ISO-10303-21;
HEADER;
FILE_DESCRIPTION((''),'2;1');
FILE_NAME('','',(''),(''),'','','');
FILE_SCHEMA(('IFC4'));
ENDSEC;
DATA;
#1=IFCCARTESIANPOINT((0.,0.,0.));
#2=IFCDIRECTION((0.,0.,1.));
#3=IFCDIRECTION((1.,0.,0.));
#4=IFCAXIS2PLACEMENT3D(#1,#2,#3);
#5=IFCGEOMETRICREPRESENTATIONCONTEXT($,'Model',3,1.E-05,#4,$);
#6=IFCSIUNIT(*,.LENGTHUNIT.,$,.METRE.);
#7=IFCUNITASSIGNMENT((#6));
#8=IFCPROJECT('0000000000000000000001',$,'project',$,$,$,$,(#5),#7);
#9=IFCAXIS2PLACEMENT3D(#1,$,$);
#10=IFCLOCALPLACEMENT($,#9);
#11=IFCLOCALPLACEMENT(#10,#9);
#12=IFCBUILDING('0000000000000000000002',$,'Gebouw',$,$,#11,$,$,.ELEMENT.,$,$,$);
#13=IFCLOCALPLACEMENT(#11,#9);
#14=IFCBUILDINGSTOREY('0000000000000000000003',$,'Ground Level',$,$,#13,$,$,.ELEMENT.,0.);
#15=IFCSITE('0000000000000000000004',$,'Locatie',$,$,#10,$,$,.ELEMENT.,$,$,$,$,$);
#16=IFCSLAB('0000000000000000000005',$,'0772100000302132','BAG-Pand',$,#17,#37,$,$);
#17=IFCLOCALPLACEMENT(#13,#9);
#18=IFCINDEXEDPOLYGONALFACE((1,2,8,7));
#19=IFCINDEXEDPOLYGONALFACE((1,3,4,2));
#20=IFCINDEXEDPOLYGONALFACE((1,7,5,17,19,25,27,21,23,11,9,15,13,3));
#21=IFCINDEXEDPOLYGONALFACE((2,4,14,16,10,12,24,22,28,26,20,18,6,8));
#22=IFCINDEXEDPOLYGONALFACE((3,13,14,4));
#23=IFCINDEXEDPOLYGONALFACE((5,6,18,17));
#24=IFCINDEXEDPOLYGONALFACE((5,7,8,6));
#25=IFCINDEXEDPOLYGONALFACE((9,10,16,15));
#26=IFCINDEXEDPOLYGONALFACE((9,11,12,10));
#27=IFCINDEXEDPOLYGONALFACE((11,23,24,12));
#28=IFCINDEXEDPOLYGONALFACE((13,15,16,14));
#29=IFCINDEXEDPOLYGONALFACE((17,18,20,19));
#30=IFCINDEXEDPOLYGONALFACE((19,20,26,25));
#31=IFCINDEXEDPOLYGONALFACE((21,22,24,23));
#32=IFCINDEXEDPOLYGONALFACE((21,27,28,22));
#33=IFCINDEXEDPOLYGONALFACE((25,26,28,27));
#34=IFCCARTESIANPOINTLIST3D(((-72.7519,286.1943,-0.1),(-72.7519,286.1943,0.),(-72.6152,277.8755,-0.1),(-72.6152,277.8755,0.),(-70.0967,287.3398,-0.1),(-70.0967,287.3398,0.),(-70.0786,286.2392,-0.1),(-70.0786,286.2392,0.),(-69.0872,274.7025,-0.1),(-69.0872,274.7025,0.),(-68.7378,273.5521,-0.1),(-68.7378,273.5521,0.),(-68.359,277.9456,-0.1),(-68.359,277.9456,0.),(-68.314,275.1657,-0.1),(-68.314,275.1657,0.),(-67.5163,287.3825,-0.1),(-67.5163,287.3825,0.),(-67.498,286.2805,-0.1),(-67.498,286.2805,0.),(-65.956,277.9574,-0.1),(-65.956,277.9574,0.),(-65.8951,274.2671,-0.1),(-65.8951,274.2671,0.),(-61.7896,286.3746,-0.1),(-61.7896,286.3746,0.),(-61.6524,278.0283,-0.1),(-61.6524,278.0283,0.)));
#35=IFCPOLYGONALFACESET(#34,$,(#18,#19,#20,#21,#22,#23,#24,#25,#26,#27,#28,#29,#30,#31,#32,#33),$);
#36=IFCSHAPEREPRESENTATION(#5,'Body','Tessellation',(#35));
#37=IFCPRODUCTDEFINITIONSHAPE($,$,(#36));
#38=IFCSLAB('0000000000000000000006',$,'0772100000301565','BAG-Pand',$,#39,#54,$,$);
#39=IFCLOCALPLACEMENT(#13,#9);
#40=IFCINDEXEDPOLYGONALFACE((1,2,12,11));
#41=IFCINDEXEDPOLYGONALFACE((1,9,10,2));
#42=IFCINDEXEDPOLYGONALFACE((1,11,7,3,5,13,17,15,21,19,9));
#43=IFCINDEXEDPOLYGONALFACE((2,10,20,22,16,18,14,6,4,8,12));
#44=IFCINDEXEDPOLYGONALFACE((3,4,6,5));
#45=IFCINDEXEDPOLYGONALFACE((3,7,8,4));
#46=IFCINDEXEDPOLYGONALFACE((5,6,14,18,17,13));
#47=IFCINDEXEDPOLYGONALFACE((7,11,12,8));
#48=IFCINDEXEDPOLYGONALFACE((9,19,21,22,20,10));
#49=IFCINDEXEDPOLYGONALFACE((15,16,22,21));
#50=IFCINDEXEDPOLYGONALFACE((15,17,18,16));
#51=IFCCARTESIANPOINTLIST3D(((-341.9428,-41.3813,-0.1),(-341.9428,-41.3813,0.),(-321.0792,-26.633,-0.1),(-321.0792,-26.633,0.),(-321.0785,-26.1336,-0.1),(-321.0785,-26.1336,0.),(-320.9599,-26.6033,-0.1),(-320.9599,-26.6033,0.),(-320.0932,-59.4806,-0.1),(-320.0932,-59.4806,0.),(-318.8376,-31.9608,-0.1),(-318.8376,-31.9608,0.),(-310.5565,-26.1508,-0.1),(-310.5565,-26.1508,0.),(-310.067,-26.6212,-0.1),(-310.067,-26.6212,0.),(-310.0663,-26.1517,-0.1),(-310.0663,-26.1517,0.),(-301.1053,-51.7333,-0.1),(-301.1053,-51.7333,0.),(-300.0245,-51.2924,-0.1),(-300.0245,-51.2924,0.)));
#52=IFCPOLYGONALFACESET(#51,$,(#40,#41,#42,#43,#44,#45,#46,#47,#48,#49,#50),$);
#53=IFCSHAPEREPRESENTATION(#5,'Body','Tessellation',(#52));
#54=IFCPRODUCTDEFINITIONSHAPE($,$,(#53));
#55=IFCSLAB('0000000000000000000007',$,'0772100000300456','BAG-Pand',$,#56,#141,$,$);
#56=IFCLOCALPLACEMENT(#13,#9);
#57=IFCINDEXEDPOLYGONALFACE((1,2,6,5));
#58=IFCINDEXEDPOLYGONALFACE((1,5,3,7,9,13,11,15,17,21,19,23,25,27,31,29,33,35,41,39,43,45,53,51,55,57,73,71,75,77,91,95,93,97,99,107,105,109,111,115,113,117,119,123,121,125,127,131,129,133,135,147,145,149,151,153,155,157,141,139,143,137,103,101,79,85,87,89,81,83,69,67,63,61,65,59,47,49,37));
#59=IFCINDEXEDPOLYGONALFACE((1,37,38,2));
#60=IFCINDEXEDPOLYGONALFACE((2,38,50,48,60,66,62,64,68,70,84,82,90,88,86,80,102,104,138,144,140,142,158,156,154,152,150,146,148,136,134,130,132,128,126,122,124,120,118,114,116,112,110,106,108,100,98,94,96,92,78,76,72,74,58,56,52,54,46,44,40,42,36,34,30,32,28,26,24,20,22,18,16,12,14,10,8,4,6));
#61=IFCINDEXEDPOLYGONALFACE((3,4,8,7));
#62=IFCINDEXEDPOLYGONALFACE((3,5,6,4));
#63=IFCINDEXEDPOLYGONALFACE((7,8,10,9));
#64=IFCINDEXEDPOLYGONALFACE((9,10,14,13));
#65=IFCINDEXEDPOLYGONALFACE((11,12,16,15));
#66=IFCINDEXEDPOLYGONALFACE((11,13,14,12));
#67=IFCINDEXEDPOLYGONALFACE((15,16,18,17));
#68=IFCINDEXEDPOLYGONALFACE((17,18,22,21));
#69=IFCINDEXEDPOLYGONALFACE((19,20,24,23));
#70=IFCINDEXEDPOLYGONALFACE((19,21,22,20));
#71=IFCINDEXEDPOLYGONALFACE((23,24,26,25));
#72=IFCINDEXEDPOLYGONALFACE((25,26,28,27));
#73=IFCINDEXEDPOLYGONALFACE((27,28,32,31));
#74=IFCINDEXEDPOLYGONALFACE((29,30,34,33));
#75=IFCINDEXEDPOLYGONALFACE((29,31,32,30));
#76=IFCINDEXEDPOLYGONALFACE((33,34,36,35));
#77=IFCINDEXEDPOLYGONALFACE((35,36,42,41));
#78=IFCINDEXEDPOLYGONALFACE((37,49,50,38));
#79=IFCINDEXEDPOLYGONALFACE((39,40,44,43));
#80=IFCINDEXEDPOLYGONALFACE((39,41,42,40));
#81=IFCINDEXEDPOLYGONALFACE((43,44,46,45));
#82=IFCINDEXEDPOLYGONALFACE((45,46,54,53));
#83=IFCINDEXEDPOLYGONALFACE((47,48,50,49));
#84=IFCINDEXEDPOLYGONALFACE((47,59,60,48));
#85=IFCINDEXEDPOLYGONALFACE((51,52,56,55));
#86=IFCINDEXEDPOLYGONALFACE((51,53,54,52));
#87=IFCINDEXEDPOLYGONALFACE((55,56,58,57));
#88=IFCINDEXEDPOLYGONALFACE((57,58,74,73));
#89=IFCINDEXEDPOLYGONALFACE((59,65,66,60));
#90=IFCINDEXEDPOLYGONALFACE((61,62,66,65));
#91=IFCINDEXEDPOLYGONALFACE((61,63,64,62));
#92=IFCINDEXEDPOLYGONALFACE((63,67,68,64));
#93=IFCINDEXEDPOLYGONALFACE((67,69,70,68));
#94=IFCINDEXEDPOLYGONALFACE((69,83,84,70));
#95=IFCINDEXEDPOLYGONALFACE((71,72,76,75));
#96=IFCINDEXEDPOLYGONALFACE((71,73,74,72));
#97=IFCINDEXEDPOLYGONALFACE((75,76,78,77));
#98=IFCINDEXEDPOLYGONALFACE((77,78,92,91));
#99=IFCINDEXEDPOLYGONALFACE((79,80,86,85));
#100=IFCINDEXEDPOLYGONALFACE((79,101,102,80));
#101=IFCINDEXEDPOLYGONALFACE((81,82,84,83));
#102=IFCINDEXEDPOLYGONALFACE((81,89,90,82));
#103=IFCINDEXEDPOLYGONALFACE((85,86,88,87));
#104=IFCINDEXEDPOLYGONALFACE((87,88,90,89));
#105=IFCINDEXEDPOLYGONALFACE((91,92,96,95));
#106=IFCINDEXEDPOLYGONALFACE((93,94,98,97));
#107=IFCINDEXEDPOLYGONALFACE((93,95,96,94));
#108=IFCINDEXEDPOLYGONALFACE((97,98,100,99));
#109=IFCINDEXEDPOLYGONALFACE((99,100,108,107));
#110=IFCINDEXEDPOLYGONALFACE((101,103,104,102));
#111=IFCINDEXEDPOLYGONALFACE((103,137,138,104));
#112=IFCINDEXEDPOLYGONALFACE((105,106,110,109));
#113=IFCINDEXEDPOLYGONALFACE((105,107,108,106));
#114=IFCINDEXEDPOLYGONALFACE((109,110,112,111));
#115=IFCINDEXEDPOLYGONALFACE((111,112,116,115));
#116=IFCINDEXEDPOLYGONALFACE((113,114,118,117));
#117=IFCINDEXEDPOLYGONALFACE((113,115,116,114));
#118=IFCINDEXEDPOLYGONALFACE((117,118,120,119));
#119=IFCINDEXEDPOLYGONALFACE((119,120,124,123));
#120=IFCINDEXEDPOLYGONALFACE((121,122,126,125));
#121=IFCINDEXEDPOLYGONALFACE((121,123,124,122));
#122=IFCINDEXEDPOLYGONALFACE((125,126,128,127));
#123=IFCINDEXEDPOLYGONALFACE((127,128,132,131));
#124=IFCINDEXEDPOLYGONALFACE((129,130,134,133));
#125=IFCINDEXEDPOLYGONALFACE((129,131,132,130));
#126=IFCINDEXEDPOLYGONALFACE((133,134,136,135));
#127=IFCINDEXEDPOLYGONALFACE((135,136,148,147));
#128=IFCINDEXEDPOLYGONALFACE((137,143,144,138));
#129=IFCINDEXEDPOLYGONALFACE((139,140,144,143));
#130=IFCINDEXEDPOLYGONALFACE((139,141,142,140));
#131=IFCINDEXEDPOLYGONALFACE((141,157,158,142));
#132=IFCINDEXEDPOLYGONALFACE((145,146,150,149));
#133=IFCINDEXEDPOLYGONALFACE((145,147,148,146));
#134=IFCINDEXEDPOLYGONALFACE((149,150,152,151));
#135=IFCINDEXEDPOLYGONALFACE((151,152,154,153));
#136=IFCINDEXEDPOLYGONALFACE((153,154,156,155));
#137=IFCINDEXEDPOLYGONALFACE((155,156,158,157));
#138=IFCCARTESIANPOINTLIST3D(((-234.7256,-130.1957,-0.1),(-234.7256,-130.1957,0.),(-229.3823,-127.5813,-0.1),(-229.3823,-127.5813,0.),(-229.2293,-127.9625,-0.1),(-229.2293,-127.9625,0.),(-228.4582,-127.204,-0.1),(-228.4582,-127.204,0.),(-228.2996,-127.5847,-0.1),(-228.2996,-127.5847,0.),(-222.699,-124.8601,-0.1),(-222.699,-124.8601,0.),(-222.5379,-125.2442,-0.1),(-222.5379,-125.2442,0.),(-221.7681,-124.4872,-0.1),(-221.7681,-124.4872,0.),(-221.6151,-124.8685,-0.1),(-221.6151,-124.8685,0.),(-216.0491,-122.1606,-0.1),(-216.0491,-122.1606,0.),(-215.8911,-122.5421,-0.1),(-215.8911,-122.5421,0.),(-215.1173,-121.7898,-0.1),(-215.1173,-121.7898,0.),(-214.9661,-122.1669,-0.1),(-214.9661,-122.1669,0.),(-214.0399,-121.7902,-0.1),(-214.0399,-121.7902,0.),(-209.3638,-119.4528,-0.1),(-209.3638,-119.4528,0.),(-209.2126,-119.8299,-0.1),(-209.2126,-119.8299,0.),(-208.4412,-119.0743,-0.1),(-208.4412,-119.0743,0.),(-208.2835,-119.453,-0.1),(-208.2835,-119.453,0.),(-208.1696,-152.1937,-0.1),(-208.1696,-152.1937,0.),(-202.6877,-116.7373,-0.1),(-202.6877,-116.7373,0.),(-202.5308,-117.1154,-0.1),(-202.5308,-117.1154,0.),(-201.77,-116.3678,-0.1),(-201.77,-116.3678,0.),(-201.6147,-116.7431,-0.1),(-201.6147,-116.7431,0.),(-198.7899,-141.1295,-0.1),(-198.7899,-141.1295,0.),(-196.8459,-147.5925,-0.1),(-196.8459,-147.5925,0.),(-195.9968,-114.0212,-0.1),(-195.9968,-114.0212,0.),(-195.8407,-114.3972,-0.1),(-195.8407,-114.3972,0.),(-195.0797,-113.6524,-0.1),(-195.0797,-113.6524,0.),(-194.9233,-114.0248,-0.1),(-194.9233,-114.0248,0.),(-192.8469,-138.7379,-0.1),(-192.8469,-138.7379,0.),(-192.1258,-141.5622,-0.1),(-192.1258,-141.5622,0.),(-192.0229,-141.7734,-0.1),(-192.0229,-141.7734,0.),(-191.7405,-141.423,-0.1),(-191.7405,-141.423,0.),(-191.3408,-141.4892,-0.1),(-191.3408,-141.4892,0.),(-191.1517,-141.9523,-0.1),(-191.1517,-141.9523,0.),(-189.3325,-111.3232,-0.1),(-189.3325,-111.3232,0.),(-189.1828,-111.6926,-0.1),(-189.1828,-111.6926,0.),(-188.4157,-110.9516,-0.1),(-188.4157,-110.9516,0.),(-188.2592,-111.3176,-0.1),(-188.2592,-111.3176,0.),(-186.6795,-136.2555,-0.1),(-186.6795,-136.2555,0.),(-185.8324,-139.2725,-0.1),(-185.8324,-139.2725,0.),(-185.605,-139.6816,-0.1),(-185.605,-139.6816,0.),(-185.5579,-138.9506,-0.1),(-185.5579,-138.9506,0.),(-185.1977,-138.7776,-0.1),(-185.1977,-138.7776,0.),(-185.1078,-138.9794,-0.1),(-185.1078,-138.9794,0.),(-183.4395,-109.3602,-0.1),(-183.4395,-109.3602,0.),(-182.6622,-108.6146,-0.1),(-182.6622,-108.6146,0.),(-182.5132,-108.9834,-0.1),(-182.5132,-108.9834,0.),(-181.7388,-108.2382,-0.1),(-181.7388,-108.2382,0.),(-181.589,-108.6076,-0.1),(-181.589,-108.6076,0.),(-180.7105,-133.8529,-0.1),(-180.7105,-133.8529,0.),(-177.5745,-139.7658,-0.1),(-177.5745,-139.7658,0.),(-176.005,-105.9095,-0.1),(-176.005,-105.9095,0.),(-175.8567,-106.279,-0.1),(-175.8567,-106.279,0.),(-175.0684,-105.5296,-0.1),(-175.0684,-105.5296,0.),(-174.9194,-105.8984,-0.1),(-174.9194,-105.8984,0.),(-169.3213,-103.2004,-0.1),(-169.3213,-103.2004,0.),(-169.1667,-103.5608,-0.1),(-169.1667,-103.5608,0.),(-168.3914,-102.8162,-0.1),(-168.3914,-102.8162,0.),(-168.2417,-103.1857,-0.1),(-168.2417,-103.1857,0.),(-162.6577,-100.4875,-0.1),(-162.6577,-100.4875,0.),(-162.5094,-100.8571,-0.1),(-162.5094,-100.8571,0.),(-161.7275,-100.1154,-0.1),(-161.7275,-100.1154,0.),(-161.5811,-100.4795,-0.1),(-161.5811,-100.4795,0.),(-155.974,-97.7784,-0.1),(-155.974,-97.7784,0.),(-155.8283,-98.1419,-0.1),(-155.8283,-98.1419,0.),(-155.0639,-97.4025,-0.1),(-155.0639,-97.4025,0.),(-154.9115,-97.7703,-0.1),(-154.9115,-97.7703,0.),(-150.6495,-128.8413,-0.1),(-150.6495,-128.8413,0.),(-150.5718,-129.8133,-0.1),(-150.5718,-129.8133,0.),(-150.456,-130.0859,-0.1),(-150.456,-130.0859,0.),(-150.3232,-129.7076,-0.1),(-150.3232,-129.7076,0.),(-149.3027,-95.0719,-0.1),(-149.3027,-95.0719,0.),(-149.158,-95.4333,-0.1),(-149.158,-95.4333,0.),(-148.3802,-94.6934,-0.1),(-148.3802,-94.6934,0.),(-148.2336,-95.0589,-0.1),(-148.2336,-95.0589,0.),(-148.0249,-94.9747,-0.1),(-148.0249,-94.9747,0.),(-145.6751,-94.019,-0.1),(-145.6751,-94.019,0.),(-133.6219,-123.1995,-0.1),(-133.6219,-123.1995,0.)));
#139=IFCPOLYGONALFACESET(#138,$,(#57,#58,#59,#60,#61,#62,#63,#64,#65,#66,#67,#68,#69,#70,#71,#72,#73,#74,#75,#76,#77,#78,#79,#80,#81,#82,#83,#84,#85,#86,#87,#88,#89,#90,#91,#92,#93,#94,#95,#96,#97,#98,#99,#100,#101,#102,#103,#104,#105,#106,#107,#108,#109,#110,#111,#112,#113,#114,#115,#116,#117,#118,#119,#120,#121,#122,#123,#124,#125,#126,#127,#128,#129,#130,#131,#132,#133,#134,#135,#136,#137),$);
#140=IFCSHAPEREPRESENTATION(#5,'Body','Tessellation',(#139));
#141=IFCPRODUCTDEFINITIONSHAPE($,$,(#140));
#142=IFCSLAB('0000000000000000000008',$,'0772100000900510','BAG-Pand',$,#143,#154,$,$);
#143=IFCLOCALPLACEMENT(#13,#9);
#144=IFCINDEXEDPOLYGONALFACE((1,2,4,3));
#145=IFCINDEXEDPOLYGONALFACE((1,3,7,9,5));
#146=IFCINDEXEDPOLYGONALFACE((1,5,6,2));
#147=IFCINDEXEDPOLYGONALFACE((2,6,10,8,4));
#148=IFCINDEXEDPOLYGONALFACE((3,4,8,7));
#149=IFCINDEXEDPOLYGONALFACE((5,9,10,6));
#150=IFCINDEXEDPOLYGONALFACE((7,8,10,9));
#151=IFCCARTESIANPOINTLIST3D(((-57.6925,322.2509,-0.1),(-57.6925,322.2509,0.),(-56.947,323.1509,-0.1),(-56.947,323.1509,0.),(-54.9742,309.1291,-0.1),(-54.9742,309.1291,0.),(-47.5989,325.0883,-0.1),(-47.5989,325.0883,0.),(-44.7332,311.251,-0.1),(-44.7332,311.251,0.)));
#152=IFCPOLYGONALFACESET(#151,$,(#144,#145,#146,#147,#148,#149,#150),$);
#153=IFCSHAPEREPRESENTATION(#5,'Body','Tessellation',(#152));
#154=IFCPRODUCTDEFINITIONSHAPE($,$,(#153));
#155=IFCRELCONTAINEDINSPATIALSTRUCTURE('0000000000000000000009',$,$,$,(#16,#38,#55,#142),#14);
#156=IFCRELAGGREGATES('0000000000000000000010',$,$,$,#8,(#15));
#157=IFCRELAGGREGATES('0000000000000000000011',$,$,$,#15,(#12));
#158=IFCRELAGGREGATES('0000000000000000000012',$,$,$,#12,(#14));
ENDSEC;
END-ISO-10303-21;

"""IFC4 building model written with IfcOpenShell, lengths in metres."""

from ifc_helpers import new_model, si_unit, frame, origin, origin_with_axes, place, context, project, spatial, polyline, outline, extrude, element, save


model = new_model("IFC4")

# Units and contexts
model_context = context("Model", 3, precision=1e-05, world=origin_with_axes())
ifc_project = project(units=[si_unit("LENGTHUNIT", "METRE")], contexts=[model_context])

# Site, building, storey
site_placement = place(None, origin())
site = spatial("IfcSite", under=ifc_project, at=site_placement, Name="Locatie", CompositionType="ELEMENT")
building_placement = place(site_placement, origin())
building = spatial("IfcBuilding", under=site, at=building_placement, Name="Gebouw", CompositionType="ELEMENT")
storey_placement = place(building_placement, origin())
storey = spatial("IfcBuildingStorey", under=building, at=storey_placement, Name="Ground Level", CompositionType="ELEMENT", Elevation=0.0)

# Slabs
slab_1_placement = place(storey_placement, origin())
element("IfcSlab", 1, at=slab_1_placement, inside=storey, Name="0772100000302132", Description="BAG-Pand", context=model_context, shape_type="SweptSolid", body=[
    extrude(outline(polyline([(-69.0872, 274.7025), (-68.314, 275.1657), (-68.359, 277.9456), (-72.6152, 277.8755), (-72.7519, 286.1943), (-70.0786, 286.2392), (-70.0967, 287.3398), (-67.5163, 287.3825), (-67.498, 286.2805), (-61.7896, 286.3746), (-61.6524, 278.0283), (-65.956, 277.9574), (-65.8951, 274.2671), (-68.7378, 273.5521), (-69.0872, 274.7025)])), frame((0.0, 0.0, -0.1), z_axis=(0.0, 0.0, 1.0), x_axis=(1.0, 0.0, 0.0)), (0.0, 0.0, 1.0), 0.1),
])
slab_2_placement = place(storey_placement, origin())
element("IfcSlab", 2, at=slab_2_placement, inside=storey, Name="0772100000301565", Description="BAG-Pand", context=model_context, shape_type="SweptSolid", body=[
    extrude(outline(polyline([(-318.8376, -31.9608), (-320.9599, -26.6033), (-321.0792, -26.633), (-321.0785, -26.1336), (-310.5565, -26.1508), (-310.0663, -26.1517), (-310.067, -26.6212), (-300.0245, -51.2924), (-301.1053, -51.7333), (-320.0932, -59.4806), (-341.9428, -41.3813), (-318.8376, -31.9608)])), frame((0.0, 0.0, -0.1), z_axis=(0.0, 0.0, 1.0), x_axis=(1.0, 0.0, 0.0)), (0.0, 0.0, 1.0), 0.1),
])
slab_3_placement = place(storey_placement, origin())
element("IfcSlab", 3, at=slab_3_placement, inside=storey, Name="0772100000300456", Description="BAG-Pand", context=model_context, shape_type="SweptSolid", body=[
    extrude(outline(polyline([(-229.2293, -127.9625), (-229.3823, -127.5813), (-228.4582, -127.204), (-228.2996, -127.5847), (-222.5379, -125.2442), (-222.699, -124.8601), (-221.7681, -124.4872), (-221.6151, -124.8685), (-215.8911, -122.5421), (-216.0491, -122.1606), (-215.1173, -121.7898), (-214.9661, -122.1669), (-214.0399, -121.7902), (-209.2126, -119.8299), (-209.3638, -119.4528), (-208.4412, -119.0743), (-208.2835, -119.453), (-202.5308, -117.1154), (-202.6877, -116.7373), (-201.77, -116.3678), (-201.6147, -116.7431), (-195.8407, -114.3972), (-195.9968, -114.0212), (-195.0797, -113.6524), (-194.9233, -114.0248), (-189.1828, -111.6926), (-189.3325, -111.3232), (-188.4157, -110.9516), (-188.2592, -111.3176), (-183.4395, -109.3602), (-182.5132, -108.9834), (-182.6622, -108.6146), (-181.7388, -108.2382), (-181.589, -108.6076), (-175.8567, -106.279), (-176.005, -105.9095), (-175.0684, -105.5296), (-174.9194, -105.8984), (-169.1667, -103.5608), (-169.3213, -103.2004), (-168.3914, -102.8162), (-168.2417, -103.1857), (-162.5094, -100.8571), (-162.6577, -100.4875), (-161.7275, -100.1154), (-161.5811, -100.4795), (-155.8283, -98.1419), (-155.974, -97.7784), (-155.0639, -97.4025), (-154.9115, -97.7703), (-149.158, -95.4333), (-149.3027, -95.0719), (-148.3802, -94.6934), (-148.2336, -95.0589), (-148.0249, -94.9747), (-145.6751, -94.019), (-133.6219, -123.1995), (-150.456, -130.0859), (-150.5718, -129.8133), (-150.3232, -129.7076), (-150.6495, -128.8413), (-177.5745, -139.7658), (-180.7105, -133.8529), (-186.6795, -136.2555), (-185.5579, -138.9506), (-185.1977, -138.7776), (-185.1078, -138.9794), (-185.8324, -139.2725), (-185.605, -139.6816), (-191.1517, -141.9523), (-191.3408, -141.4892), (-192.0229, -141.7734), (-192.1258, -141.5622), (-191.7405, -141.423), (-192.8469, -138.7379), (-198.7899, -141.1295), (-196.8459, -147.5925), (-208.1696, -152.1937), (-234.7256, -130.1957), (-229.2293, -127.9625)])), frame((0.0, 0.0, -0.1), z_axis=(0.0, 0.0, 1.0), x_axis=(1.0, 0.0, 0.0)), (0.0, 0.0, 1.0), 0.1),
])
slab_4_placement = place(storey_placement, origin())
element("IfcSlab", 4, at=slab_4_placement, inside=storey, Name="0772100000900510", Description="BAG-Pand", context=model_context, shape_type="SweptSolid", body=[
    extrude(outline(polyline([(-47.5989, 325.0883), (-44.7332, 311.251), (-54.9742, 309.1291), (-57.6925, 322.2509), (-56.947, 323.1509), (-47.5989, 325.0883)])), frame((0.0, 0.0, -0.1), z_axis=(0.0, 0.0, 1.0), x_axis=(1.0, 0.0, 0.0)), (0.0, 0.0, 1.0), 0.1),
])

save(model, "model.ifc")
